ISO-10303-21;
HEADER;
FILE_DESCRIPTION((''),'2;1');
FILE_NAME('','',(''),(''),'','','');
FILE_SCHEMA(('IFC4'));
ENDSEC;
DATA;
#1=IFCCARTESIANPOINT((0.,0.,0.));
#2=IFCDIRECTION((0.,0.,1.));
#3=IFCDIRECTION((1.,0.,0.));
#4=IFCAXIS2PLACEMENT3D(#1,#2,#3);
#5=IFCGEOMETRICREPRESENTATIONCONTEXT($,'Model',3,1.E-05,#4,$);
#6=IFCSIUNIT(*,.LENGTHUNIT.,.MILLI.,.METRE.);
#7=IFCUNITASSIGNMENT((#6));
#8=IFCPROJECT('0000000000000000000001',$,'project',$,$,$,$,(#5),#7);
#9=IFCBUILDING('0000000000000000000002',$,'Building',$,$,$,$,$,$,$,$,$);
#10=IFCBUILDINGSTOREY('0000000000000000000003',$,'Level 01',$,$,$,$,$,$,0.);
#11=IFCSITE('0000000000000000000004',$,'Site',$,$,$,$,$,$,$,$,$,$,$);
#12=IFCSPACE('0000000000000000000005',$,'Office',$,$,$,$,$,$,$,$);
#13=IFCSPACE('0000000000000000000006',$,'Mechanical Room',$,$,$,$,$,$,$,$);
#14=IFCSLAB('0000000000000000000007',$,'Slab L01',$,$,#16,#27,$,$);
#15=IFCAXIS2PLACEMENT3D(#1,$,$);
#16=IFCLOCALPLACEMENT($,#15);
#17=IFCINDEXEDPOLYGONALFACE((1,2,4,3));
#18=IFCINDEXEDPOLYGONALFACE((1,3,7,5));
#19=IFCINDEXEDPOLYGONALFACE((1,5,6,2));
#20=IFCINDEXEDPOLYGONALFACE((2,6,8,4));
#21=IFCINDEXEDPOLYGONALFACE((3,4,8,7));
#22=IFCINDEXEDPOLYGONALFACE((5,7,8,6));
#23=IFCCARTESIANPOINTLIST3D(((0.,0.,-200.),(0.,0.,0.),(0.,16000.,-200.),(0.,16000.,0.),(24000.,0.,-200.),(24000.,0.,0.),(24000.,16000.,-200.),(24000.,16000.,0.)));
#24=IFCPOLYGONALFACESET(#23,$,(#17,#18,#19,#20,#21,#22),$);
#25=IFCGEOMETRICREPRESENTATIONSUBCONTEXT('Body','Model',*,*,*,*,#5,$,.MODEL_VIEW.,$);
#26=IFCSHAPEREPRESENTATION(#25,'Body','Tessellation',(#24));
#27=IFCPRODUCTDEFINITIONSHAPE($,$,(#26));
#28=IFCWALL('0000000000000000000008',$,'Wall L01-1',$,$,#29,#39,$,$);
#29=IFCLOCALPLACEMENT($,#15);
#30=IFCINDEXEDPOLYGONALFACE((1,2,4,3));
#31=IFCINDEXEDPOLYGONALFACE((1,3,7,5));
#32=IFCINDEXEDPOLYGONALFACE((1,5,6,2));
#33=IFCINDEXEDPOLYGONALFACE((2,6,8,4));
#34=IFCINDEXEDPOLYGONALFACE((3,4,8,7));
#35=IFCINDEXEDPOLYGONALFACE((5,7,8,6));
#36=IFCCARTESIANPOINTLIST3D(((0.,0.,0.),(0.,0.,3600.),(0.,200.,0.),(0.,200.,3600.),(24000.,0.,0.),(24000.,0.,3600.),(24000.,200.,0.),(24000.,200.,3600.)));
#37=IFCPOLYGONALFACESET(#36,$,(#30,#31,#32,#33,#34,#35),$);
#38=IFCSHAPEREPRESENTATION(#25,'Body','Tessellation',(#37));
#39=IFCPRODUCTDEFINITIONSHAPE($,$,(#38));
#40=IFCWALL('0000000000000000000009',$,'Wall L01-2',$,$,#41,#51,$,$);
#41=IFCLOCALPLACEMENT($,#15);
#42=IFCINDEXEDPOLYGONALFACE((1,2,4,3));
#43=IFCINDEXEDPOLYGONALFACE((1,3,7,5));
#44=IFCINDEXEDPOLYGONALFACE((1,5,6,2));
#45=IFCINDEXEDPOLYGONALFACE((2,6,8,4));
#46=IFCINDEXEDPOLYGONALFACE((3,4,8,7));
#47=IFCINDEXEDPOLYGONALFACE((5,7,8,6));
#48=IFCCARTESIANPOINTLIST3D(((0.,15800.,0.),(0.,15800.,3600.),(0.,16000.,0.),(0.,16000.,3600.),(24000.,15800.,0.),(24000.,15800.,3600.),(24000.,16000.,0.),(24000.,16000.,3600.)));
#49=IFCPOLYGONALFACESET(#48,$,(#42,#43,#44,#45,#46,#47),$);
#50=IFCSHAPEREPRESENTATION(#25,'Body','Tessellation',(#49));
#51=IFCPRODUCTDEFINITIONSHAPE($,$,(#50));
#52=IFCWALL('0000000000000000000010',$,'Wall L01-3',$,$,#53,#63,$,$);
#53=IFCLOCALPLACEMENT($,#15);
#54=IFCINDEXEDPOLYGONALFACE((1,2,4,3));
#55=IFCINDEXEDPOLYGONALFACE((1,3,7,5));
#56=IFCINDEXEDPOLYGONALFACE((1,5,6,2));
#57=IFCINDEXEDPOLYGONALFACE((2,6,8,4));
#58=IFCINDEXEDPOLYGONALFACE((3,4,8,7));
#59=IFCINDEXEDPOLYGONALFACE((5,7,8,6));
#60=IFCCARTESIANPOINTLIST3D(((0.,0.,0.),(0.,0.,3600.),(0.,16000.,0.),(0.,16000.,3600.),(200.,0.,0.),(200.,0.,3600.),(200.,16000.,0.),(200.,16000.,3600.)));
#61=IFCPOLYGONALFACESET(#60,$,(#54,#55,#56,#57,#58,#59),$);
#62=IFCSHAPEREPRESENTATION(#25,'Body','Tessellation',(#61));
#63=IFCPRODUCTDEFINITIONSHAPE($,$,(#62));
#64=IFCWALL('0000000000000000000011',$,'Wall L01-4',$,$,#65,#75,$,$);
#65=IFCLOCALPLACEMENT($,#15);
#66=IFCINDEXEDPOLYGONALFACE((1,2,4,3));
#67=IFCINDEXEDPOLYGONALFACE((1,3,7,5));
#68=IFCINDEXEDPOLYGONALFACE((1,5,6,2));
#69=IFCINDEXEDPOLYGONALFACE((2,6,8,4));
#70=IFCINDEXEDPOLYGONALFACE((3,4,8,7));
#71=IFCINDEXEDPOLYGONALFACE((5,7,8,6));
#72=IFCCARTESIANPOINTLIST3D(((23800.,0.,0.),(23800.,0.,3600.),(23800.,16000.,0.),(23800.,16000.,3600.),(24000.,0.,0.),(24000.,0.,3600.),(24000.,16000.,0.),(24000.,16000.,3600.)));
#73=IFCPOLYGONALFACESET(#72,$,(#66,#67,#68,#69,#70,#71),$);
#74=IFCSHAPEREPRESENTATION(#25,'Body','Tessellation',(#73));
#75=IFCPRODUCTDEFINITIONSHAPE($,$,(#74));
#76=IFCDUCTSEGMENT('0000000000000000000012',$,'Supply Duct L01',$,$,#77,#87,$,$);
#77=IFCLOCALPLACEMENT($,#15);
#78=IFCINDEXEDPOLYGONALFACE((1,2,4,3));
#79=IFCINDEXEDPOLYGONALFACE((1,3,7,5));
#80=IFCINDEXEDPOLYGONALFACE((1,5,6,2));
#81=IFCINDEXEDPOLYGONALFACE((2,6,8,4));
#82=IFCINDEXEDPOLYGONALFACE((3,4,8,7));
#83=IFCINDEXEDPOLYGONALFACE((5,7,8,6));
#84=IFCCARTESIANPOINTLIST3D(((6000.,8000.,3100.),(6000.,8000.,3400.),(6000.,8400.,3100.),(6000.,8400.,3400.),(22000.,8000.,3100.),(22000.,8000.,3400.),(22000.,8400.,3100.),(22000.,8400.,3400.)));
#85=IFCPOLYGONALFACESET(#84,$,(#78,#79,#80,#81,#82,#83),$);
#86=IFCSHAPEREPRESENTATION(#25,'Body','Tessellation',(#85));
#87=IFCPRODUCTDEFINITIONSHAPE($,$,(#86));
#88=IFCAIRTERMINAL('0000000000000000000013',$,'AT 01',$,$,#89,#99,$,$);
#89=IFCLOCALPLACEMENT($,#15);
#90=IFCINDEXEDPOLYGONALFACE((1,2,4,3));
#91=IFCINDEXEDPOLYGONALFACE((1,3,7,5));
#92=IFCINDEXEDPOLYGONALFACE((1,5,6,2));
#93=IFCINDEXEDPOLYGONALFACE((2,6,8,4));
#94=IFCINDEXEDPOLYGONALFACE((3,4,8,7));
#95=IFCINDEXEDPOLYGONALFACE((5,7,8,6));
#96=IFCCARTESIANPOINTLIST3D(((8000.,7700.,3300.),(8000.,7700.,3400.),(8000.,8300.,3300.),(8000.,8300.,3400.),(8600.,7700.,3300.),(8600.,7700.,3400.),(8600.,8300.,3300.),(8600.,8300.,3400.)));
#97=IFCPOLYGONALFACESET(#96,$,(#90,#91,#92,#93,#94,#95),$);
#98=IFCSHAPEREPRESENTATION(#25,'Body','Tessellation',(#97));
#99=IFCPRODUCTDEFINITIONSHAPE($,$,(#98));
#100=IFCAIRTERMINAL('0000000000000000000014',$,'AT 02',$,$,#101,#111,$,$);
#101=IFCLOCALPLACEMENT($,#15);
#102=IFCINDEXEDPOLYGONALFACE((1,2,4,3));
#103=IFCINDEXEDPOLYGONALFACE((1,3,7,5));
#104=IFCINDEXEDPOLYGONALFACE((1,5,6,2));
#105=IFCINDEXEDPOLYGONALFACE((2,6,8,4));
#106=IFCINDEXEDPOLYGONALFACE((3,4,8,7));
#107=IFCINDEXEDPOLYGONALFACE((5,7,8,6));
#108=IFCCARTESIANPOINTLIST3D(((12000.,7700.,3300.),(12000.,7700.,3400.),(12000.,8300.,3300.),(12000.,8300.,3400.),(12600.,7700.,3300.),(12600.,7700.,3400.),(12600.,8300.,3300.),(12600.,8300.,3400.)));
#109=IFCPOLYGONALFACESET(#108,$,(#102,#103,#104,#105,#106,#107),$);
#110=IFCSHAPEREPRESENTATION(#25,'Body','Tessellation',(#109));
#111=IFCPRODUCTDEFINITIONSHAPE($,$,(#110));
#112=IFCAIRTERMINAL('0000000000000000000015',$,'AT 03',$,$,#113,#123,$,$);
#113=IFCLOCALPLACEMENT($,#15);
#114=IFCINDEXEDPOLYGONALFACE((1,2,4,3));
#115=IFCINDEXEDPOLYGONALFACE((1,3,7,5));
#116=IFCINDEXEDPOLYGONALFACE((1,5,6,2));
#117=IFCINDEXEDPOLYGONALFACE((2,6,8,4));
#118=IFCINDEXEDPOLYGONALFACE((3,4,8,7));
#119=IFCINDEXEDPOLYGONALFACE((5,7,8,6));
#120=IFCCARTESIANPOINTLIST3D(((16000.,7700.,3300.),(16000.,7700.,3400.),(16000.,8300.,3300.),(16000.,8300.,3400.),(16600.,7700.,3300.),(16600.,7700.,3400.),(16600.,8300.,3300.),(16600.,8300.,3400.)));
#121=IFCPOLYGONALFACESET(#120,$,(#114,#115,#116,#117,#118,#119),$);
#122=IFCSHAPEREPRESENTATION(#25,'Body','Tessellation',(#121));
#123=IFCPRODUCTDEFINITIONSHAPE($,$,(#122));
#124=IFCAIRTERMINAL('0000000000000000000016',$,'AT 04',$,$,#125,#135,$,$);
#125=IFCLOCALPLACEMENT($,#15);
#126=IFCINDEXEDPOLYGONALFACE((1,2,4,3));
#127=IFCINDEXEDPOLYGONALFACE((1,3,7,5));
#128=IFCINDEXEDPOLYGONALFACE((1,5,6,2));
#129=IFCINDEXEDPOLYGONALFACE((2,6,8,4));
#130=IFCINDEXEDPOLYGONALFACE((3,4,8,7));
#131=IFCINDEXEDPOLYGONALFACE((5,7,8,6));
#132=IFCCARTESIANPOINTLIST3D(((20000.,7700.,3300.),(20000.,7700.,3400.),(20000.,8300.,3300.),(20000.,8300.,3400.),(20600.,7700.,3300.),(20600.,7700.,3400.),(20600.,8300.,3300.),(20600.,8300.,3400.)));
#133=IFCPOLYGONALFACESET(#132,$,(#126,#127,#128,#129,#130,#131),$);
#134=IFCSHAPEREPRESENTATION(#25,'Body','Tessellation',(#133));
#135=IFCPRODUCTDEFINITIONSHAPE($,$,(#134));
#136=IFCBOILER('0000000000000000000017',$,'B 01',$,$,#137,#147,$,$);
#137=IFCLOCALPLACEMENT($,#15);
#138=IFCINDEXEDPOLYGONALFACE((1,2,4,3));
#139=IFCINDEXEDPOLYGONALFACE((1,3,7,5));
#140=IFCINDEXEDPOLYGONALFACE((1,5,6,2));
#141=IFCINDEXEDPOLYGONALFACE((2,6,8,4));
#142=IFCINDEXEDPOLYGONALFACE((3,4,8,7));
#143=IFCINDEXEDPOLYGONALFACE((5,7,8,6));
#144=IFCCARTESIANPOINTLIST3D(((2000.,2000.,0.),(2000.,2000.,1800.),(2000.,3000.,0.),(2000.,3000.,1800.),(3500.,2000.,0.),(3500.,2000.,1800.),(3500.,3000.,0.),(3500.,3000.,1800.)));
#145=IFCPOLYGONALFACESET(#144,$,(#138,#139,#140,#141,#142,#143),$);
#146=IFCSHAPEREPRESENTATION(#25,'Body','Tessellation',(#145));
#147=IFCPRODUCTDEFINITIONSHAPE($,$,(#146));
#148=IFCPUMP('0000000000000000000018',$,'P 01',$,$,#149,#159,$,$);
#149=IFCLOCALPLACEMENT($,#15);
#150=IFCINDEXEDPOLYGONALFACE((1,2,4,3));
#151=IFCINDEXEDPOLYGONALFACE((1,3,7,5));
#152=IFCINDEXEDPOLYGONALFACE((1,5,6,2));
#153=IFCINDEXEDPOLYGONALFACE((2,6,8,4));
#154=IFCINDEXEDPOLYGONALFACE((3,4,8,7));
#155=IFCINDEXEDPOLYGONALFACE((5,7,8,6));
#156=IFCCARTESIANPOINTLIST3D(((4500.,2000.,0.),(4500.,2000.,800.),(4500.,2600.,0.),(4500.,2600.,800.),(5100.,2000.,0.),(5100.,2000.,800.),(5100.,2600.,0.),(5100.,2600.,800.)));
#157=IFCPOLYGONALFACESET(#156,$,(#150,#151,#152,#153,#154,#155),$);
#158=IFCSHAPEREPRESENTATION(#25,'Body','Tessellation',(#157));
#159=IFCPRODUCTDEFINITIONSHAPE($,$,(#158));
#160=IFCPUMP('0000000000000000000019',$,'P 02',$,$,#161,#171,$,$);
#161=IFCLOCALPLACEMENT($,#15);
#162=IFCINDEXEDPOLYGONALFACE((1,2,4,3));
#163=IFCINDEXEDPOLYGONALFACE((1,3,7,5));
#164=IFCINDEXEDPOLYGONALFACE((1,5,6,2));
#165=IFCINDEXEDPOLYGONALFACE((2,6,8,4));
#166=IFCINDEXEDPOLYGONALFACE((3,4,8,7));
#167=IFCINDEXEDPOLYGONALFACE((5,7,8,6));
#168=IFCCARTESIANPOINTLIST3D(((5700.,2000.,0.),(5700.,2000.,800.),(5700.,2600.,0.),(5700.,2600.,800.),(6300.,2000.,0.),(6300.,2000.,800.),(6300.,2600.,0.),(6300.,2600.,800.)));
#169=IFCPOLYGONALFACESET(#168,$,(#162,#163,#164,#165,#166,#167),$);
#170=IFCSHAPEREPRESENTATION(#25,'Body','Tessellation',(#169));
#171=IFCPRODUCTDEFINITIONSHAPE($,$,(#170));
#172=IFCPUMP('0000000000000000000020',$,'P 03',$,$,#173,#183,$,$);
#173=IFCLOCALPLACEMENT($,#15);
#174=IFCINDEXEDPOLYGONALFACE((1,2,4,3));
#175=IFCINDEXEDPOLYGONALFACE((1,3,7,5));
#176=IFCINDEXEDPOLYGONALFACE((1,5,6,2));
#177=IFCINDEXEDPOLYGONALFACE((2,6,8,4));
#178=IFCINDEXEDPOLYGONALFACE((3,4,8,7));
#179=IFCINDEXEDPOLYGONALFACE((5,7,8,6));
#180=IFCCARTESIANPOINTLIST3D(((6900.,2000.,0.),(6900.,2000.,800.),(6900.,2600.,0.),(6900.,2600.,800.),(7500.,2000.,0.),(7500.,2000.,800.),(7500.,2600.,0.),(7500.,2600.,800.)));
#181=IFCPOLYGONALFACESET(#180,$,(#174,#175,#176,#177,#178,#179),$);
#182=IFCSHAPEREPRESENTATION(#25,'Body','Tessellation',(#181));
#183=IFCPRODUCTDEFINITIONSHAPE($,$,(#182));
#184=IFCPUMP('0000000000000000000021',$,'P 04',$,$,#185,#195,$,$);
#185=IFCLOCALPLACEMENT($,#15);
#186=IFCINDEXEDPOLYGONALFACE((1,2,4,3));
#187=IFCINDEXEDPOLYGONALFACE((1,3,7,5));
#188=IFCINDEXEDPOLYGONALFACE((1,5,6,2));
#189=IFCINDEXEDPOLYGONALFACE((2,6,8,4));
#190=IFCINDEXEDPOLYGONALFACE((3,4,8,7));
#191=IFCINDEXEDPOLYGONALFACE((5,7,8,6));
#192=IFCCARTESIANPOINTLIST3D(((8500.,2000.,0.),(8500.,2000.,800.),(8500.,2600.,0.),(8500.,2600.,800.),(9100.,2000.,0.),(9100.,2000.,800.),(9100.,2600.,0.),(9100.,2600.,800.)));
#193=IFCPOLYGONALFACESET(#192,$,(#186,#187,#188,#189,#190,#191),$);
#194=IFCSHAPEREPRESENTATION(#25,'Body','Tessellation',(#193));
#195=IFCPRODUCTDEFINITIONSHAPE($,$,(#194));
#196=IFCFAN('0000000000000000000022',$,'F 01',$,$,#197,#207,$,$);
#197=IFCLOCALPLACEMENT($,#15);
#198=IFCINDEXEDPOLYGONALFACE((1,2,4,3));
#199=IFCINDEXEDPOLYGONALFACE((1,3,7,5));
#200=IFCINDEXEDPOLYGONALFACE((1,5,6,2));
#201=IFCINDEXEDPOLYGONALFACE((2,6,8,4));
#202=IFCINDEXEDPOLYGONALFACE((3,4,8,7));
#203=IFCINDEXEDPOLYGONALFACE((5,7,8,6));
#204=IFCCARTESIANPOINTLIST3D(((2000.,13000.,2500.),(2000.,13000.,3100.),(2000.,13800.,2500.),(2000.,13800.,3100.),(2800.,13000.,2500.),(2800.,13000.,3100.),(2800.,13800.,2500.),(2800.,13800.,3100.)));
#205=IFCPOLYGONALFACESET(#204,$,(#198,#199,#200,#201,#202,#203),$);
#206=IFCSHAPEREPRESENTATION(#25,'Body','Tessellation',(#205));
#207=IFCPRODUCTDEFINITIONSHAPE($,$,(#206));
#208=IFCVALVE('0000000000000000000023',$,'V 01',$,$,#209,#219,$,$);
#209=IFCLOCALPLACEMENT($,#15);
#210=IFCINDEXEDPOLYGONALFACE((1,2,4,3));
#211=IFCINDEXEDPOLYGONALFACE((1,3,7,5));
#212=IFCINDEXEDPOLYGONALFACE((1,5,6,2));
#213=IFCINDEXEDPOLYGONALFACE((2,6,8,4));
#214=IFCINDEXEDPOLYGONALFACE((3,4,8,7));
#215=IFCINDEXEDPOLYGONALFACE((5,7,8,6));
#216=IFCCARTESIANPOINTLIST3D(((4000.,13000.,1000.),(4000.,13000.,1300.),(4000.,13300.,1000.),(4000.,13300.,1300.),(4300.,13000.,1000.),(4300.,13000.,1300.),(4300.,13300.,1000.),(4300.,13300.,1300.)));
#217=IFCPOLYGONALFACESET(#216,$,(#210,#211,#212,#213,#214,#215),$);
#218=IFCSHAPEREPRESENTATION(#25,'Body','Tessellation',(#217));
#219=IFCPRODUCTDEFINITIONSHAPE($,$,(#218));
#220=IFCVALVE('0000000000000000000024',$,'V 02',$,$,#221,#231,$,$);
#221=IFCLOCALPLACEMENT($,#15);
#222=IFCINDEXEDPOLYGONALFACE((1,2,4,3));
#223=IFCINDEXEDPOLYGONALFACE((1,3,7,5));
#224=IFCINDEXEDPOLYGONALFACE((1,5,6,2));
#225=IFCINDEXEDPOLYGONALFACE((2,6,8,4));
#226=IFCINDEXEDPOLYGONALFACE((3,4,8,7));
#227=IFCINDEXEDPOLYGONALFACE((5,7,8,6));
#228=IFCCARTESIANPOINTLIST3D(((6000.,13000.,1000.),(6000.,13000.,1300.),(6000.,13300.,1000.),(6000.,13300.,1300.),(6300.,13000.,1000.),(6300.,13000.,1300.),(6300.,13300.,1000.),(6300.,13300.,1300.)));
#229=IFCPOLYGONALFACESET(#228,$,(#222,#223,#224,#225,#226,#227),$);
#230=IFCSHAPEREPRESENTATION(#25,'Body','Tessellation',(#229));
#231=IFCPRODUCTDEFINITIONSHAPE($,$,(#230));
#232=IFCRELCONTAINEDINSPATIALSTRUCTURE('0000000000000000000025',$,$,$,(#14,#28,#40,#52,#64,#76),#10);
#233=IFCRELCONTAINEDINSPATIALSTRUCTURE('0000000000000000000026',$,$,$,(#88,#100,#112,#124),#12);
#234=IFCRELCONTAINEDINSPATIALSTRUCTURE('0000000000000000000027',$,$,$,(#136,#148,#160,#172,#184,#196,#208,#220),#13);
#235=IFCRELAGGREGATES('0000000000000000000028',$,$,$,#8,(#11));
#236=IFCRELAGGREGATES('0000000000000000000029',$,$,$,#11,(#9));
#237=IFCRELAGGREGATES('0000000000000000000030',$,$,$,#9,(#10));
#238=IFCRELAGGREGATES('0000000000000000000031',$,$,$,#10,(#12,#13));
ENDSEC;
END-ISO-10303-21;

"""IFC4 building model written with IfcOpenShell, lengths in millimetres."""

from ifc_helpers import new_model, si_unit, frame, origin_with_axes, place, context, subcontext, project, spatial, indexed_curve, outline, extrude, element, save


model = new_model("IFC4")

# Units and contexts
model_context = context("Model", 3, precision=1e-05, world=origin_with_axes())
body_context = subcontext(model_context, "Body", "Model", "MODEL_VIEW")
ifc_project = project(units=[si_unit("LENGTHUNIT", "METRE", prefix="MILLI")], contexts=[model_context])

# Site, building, storey
site = spatial("IfcSite", under=ifc_project, Name="Site")
building = spatial("IfcBuilding", under=site, Name="Building")
storey = spatial("IfcBuildingStorey", under=building, Name="Level 01", Elevation=0.0)

# Slab
slab_placement = place(None, frame((0.0, 0.0, -200.0), z_axis=(0.0, 0.0, 1.0), x_axis=(1.0, 0.0, 0.0)))
element("IfcSlab", 1, at=slab_placement, inside=storey, Name="Slab L01", context=body_context, shape_type="SweptSolid", body=[
    extrude(outline(indexed_curve([(0.0, 0.0), (0.0, 16000.0), (24000.0, 16000.0), (24000.0, 0.0), (0.0, 0.0)], self_intersect=False)), origin_with_axes(), (0.0, 0.0, 1.0), 200.0),
])

# Walls
for number, where, z_axis, x_axis, name in (
    (2, (0.0, 0.0, 0.0), (0.0, 0.0, 1.0), (1.0, 0.0, 0.0), "Wall L01-1"),
    (3, (0.0, 15800.0, 0.0), (0.0, 0.0, 1.0), (1.0, 0.0, 0.0), "Wall L01-2"),
):
    element("IfcWall", number, at=place(None, frame(where, z_axis=z_axis, x_axis=x_axis)), inside=storey, Name=name, context=body_context, shape_type="SweptSolid", body=[
        extrude(outline(indexed_curve([(0.0, 0.0), (0.0, 200.0), (24000.0, 200.0), (24000.0, 0.0), (0.0, 0.0)], self_intersect=False)), origin_with_axes(), (0.0, 0.0, 1.0), 3600.0),
    ])
for number, where, z_axis, x_axis, name in (
    (4, (0.0, 0.0, 0.0), (0.0, 0.0, 1.0), (1.0, 0.0, 0.0), "Wall L01-3"),
    (5, (23800.0, 0.0, 0.0), (0.0, 0.0, 1.0), (1.0, 0.0, 0.0), "Wall L01-4"),
):
    element("IfcWall", number, at=place(None, frame(where, z_axis=z_axis, x_axis=x_axis)), inside=storey, Name=name, context=body_context, shape_type="SweptSolid", body=[
        extrude(outline(indexed_curve([(0.0, 0.0), (0.0, 16000.0), (200.0, 16000.0), (200.0, 0.0), (0.0, 0.0)], self_intersect=False)), origin_with_axes(), (0.0, 0.0, 1.0), 3600.0),
    ])

# Duct segment
duct_segment_placement = place(None, frame((6000.0, 8000.0, 3100.0), z_axis=(0.0, 0.0, 1.0), x_axis=(1.0, 0.0, 0.0)))
element("IfcDuctSegment", 6, at=duct_segment_placement, inside=storey, Name="Supply Duct L01", context=body_context, shape_type="SweptSolid", body=[
    extrude(outline(indexed_curve([(0.0, 0.0), (0.0, 400.0), (16000.0, 400.0), (16000.0, 0.0), (0.0, 0.0)], self_intersect=False)), origin_with_axes(), (0.0, 0.0, 1.0), 300.0),
])

# Shared definitions
space_1 = spatial("IfcSpace", under=storey, Name="Office")

# Air terminals
for number, where, z_axis, x_axis, name in (
    (7, (8000.0, 7700.0, 3300.0), (0.0, 0.0, 1.0), (1.0, 0.0, 0.0), "AT 01"),
    (8, (12000.0, 7700.0, 3300.0), (0.0, 0.0, 1.0), (1.0, 0.0, 0.0), "AT 02"),
    (9, (16000.0, 7700.0, 3300.0), (0.0, 0.0, 1.0), (1.0, 0.0, 0.0), "AT 03"),
    (10, (20000.0, 7700.0, 3300.0), (0.0, 0.0, 1.0), (1.0, 0.0, 0.0), "AT 04"),
):
    element("IfcAirTerminal", number, at=place(None, frame(where, z_axis=z_axis, x_axis=x_axis)), inside=space_1, Name=name, context=body_context, shape_type="SweptSolid", body=[
        extrude(outline(indexed_curve([(0.0, 0.0), (0.0, 600.0), (600.0, 600.0), (600.0, 0.0), (0.0, 0.0)], self_intersect=False)), origin_with_axes(), (0.0, 0.0, 1.0), 100.0),
    ])

# Shared definitions
space_2 = spatial("IfcSpace", under=storey, Name="Mechanical Room")

# Boiler
boiler_placement = place(None, frame((2000.0, 2000.0, 0.0), z_axis=(0.0, 0.0, 1.0), x_axis=(1.0, 0.0, 0.0)))
element("IfcBoiler", 11, at=boiler_placement, inside=space_2, Name="B 01", context=body_context, shape_type="SweptSolid", body=[
    extrude(outline(indexed_curve([(0.0, 0.0), (0.0, 1000.0), (1500.0, 1000.0), (1500.0, 0.0), (0.0, 0.0)], self_intersect=False)), origin_with_axes(), (0.0, 0.0, 1.0), 1800.0),
])

# Pumps
for number, where, z_axis, x_axis, name in (
    (12, (4500.0, 2000.0, 0.0), (0.0, 0.0, 1.0), (1.0, 0.0, 0.0), "P 01"),
    (13, (5700.0, 2000.0, 0.0), (0.0, 0.0, 1.0), (1.0, 0.0, 0.0), "P 02"),
    (14, (6900.0, 2000.0, 0.0), (0.0, 0.0, 1.0), (1.0, 0.0, 0.0), "P 03"),
    (15, (8500.0, 2000.0, 0.0), (0.0, 0.0, 1.0), (1.0, 0.0, 0.0), "P 04"),
):
    element("IfcPump", number, at=place(None, frame(where, z_axis=z_axis, x_axis=x_axis)), inside=space_2, Name=name, context=body_context, shape_type="SweptSolid", body=[
        extrude(outline(indexed_curve([(0.0, 0.0), (0.0, 600.0), (600.0, 600.0), (600.0, 0.0), (0.0, 0.0)], self_intersect=False)), origin_with_axes(), (0.0, 0.0, 1.0), 800.0),
    ])

# Fan
fan_placement = place(None, frame((2000.0, 13000.0, 2500.0), z_axis=(0.0, 0.0, 1.0), x_axis=(1.0, 0.0, 0.0)))
element("IfcFan", 16, at=fan_placement, inside=space_2, Name="F 01", context=body_context, shape_type="SweptSolid", body=[
    extrude(outline(indexed_curve([(0.0, 0.0), (0.0, 800.0), (800.0, 800.0), (800.0, 0.0), (0.0, 0.0)], self_intersect=False)), origin_with_axes(), (0.0, 0.0, 1.0), 600.0),
])

# Valves
for number, where, z_axis, x_axis, name in (
    (17, (4000.0, 13000.0, 1000.0), (0.0, 0.0, 1.0), (1.0, 0.0, 0.0), "V 01"),
    (18, (6000.0, 13000.0, 1000.0), (0.0, 0.0, 1.0), (1.0, 0.0, 0.0), "V 02"),
):
    element("IfcValve", number, at=place(None, frame(where, z_axis=z_axis, x_axis=x_axis)), inside=space_2, Name=name, context=body_context, shape_type="SweptSolid", body=[
        extrude(outline(indexed_curve([(0.0, 0.0), (0.0, 300.0), (300.0, 300.0), (300.0, 0.0), (0.0, 0.0)], self_intersect=False)), origin_with_axes(), (0.0, 0.0, 1.0), 300.0),
    ])

save(model, "model.ifc")
